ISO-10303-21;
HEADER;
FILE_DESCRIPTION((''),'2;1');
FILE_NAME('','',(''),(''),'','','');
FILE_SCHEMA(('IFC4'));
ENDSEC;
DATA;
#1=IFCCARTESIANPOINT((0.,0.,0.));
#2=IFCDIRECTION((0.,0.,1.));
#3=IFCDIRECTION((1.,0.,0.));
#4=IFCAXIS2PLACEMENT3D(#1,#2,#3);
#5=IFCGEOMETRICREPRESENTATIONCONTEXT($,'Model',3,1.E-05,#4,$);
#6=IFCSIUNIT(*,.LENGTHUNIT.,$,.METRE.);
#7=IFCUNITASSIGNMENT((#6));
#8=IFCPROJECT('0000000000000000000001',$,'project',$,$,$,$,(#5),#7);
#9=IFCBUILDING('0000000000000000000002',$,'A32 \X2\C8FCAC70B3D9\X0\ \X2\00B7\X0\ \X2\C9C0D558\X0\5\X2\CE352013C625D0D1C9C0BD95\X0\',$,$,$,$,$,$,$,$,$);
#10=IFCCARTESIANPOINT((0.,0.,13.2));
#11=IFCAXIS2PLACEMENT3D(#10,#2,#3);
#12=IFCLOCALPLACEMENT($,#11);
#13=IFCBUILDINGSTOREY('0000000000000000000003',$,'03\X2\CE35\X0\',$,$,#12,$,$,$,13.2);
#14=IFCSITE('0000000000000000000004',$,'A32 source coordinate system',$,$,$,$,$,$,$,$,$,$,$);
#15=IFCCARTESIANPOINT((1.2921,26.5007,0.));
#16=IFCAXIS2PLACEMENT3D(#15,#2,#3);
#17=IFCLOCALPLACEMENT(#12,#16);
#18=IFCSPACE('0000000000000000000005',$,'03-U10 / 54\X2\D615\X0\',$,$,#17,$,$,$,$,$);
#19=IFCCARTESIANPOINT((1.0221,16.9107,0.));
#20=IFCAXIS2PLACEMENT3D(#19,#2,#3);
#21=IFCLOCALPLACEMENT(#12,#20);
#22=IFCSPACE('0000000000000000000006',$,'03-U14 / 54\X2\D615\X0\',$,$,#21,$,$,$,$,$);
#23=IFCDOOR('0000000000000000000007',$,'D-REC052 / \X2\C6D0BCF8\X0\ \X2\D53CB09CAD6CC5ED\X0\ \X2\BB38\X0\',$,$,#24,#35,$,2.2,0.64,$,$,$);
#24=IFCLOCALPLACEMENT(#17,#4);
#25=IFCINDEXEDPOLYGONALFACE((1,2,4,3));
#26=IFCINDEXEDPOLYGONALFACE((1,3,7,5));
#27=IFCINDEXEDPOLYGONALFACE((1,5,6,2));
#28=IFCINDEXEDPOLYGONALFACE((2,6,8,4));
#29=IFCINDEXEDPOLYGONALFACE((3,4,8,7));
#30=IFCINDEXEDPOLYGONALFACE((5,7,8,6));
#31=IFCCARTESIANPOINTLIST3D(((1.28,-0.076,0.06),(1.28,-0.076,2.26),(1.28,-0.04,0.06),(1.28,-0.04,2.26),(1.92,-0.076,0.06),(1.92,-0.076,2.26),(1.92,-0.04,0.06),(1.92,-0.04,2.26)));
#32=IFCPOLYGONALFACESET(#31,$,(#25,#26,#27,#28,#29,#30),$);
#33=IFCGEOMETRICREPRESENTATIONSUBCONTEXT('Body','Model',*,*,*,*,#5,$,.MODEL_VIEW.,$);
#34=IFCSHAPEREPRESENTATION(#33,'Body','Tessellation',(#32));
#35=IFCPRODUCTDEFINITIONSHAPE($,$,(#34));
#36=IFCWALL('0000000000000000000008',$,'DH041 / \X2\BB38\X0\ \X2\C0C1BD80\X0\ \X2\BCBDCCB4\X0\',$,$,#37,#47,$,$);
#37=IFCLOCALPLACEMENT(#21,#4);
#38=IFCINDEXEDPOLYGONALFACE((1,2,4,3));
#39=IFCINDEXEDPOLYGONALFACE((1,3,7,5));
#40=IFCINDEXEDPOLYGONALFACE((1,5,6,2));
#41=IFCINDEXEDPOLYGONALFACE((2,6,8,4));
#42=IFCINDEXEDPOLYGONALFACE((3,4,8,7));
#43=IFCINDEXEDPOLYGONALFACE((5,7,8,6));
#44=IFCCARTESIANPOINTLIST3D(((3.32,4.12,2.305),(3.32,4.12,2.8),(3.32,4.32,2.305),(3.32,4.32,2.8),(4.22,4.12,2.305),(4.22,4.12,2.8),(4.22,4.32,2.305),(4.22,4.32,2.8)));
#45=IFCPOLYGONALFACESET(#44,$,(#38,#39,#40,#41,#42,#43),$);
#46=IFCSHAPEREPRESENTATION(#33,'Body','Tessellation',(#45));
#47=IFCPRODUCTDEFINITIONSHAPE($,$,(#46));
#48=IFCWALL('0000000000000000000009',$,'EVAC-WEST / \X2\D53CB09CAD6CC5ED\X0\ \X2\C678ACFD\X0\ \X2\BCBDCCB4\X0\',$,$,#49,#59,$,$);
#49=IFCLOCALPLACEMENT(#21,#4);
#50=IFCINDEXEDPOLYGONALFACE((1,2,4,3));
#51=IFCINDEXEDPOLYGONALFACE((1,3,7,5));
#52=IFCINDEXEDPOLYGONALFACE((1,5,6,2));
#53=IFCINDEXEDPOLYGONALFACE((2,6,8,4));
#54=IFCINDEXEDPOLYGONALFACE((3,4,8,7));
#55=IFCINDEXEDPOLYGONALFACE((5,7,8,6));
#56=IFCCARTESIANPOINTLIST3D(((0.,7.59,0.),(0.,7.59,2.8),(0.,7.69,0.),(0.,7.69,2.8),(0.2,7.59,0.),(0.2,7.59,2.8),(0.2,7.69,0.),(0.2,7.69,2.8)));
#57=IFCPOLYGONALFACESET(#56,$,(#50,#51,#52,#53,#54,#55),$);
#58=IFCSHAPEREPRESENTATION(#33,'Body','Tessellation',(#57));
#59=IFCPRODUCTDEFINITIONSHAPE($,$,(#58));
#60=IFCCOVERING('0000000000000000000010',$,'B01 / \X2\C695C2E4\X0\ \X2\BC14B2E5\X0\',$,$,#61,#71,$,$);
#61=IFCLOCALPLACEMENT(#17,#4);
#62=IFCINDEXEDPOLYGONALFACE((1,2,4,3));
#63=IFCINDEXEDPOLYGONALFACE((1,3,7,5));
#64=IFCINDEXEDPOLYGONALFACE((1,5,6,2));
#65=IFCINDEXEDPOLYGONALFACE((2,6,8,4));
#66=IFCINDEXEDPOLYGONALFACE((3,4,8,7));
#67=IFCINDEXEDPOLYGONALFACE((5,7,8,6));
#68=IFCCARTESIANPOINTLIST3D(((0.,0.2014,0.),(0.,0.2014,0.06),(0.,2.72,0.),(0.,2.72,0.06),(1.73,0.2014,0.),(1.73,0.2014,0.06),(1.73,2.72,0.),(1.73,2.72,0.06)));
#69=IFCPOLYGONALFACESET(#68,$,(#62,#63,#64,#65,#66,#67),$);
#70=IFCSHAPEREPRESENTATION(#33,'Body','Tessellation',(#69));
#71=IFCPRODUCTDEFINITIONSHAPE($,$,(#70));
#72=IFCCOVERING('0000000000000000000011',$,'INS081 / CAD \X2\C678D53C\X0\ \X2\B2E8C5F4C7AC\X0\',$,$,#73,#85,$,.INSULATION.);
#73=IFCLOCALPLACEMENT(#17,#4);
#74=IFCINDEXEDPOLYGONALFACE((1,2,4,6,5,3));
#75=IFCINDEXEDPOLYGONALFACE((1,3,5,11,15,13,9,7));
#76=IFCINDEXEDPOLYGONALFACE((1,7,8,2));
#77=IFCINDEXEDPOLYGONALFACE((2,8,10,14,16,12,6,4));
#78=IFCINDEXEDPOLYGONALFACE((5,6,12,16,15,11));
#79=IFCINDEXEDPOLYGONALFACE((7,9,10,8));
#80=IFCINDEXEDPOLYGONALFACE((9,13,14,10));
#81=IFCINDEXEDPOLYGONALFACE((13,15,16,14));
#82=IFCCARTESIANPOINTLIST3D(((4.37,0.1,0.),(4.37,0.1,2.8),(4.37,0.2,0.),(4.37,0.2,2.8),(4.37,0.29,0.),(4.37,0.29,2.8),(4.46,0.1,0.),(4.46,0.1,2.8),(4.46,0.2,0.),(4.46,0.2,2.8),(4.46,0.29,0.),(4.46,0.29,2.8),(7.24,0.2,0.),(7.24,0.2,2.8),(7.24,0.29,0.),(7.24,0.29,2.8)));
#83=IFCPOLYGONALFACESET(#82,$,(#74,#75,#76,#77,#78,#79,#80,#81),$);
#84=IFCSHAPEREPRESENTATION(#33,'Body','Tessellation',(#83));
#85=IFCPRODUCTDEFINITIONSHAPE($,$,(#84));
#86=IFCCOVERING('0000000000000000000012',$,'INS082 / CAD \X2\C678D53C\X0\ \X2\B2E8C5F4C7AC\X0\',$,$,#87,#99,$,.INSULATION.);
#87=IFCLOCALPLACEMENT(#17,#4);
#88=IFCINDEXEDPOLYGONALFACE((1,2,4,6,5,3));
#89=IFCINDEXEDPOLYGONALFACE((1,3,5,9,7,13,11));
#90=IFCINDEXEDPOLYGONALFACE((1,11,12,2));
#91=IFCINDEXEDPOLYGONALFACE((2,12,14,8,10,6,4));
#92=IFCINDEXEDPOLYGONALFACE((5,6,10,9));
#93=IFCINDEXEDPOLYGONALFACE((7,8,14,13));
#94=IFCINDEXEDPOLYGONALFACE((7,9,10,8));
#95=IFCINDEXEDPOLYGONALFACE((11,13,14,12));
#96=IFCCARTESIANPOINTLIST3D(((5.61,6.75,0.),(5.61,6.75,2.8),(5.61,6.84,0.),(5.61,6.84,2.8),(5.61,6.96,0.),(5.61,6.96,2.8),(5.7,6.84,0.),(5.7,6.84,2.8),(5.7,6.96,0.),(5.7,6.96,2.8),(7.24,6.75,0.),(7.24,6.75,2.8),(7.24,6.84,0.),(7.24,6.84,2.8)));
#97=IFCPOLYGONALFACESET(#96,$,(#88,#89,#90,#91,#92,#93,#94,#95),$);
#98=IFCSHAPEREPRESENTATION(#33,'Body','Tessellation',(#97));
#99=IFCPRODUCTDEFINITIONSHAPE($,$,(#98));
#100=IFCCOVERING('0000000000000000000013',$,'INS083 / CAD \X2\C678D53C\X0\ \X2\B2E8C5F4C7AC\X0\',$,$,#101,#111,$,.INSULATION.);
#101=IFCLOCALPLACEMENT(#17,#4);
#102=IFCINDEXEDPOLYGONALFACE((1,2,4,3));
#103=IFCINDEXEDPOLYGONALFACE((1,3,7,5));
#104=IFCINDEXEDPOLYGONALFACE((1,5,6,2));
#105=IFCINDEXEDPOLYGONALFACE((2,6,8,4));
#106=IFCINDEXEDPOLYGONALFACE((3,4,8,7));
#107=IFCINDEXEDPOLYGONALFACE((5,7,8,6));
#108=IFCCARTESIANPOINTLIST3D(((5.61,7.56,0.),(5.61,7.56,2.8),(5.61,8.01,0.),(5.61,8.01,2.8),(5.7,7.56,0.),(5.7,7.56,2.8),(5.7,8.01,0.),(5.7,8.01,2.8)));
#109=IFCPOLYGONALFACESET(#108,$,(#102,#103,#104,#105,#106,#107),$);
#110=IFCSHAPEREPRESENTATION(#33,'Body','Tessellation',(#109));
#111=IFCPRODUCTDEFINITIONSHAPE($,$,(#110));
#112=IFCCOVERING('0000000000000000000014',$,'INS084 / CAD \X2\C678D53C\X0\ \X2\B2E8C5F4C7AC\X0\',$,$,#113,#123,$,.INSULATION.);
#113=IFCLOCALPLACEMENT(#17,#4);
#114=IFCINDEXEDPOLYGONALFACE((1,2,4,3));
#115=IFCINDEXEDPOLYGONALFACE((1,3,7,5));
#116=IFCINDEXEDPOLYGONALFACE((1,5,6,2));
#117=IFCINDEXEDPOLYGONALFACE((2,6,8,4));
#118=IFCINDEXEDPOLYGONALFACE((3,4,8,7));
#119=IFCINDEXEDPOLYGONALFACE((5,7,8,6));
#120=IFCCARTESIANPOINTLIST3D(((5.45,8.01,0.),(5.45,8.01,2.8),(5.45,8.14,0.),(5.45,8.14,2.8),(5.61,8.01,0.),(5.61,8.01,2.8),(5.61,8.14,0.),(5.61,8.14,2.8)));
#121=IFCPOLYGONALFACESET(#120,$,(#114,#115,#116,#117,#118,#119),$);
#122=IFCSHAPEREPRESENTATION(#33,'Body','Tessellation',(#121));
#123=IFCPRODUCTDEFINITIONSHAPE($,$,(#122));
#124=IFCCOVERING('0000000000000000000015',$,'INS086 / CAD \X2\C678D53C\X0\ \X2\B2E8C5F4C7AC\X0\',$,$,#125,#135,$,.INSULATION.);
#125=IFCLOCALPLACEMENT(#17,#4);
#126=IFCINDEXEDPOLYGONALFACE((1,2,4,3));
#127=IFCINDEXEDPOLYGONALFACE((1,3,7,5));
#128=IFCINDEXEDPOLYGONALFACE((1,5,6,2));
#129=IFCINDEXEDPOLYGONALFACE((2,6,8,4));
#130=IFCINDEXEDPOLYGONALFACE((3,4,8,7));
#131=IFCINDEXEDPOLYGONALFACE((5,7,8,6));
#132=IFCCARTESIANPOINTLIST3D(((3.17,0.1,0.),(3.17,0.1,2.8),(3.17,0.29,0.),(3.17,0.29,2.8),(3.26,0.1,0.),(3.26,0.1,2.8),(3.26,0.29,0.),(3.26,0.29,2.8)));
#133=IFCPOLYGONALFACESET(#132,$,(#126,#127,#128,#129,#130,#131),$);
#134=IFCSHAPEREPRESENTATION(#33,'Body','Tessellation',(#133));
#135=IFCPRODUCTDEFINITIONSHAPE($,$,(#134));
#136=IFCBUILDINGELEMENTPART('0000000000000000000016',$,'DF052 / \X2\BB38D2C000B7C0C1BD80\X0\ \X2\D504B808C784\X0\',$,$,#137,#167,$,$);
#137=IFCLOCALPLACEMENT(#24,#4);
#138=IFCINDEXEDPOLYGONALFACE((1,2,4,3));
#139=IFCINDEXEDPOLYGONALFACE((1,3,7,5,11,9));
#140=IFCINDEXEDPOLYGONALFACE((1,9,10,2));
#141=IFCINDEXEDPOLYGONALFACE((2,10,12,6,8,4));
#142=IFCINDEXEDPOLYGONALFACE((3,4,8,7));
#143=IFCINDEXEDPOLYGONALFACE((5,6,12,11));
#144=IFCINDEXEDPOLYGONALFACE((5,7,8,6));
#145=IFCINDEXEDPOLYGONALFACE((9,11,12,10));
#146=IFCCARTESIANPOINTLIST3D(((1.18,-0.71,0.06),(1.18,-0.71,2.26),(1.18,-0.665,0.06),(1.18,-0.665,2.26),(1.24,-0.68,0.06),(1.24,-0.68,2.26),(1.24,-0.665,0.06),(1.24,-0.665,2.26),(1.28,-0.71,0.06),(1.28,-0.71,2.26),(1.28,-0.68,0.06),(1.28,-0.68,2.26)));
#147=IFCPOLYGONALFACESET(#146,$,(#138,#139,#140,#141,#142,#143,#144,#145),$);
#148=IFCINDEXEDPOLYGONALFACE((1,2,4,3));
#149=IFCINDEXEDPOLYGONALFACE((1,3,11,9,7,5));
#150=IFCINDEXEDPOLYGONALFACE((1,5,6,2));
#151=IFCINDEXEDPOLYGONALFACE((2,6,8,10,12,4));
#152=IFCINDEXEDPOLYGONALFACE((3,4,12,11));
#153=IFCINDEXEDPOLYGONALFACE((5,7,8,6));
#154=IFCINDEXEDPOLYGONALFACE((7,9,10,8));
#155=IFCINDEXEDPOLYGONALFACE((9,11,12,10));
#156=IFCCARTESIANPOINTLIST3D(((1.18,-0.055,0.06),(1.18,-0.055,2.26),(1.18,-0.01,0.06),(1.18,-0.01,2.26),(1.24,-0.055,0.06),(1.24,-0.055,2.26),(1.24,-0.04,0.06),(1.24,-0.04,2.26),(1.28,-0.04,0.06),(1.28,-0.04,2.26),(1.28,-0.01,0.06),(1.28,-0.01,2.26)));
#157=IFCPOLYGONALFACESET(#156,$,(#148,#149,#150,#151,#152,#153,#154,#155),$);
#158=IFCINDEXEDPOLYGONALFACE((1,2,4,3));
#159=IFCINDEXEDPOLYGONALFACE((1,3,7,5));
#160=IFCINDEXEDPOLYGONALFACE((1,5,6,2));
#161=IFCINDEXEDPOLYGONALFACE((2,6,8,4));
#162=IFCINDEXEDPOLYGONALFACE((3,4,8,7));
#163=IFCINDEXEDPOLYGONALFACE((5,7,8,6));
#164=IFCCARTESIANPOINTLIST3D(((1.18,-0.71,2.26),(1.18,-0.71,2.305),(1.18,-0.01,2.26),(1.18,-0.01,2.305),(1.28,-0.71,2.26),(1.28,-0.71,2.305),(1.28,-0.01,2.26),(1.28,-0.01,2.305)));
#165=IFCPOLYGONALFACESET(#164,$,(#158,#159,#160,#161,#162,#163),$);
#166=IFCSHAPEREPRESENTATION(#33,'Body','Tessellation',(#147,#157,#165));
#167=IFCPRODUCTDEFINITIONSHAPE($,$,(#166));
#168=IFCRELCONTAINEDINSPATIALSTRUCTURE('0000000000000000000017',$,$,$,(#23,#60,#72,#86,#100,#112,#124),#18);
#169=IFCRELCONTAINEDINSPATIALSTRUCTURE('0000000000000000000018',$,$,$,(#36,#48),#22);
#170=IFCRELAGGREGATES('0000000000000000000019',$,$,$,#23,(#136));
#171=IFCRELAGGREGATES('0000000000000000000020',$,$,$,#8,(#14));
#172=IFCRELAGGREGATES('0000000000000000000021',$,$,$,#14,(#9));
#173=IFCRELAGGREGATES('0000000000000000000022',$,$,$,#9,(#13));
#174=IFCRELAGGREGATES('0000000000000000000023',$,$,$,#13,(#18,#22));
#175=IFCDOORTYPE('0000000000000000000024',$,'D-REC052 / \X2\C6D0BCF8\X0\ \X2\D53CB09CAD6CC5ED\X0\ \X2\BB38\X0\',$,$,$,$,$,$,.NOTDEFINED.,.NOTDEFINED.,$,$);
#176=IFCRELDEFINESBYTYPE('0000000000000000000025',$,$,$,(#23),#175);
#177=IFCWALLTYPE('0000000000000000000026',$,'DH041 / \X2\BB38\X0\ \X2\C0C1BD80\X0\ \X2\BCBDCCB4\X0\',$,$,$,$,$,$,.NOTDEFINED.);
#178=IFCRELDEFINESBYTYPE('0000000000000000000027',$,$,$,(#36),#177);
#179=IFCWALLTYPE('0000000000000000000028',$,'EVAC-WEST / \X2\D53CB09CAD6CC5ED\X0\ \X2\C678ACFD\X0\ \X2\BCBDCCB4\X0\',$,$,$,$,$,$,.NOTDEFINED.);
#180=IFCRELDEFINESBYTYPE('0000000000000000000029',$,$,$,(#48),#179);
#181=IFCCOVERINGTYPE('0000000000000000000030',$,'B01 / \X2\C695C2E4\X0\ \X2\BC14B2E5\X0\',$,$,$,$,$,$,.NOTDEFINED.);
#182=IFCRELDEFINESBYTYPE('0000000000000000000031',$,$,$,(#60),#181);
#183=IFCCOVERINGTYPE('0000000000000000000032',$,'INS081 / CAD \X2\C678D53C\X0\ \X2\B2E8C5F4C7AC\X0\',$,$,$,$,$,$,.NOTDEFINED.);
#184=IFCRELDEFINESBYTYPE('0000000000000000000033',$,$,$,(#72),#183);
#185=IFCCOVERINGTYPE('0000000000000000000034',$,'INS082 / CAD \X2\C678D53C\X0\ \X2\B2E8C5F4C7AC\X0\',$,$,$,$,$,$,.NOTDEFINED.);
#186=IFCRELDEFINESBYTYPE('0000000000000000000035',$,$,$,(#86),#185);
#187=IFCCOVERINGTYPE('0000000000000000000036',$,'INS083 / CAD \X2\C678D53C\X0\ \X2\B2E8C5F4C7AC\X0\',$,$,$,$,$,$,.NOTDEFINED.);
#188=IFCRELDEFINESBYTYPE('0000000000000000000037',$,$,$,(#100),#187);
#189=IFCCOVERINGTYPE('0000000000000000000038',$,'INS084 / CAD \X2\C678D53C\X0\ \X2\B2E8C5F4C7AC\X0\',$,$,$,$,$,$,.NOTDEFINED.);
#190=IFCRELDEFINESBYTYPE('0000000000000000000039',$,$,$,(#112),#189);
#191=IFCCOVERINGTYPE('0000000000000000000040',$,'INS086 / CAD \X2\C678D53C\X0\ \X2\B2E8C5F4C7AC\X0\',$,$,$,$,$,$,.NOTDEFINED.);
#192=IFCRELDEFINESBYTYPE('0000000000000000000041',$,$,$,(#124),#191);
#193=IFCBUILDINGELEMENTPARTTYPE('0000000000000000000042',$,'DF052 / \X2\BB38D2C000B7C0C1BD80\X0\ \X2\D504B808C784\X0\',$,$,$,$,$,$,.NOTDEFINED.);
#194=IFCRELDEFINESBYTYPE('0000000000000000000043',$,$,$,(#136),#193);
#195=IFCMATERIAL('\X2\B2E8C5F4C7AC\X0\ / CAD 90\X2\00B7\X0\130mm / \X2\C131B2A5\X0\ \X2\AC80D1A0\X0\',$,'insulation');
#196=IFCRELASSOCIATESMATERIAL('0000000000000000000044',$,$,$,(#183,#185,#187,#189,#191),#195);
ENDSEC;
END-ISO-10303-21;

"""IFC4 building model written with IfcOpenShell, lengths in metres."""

from ifc_helpers import new_model, si_unit, frame, origin, origin_with_axes, place, context, subcontext, project, spatial, polyline, outline, extrude, source, transform, mapped, material, type_object, type_shapes, element, aggregate, save


model = new_model("IFC4")

# Units and contexts
model_context = context("Model", 3, precision=1e-05, world=origin_with_axes())
body_context = subcontext(model_context, "Body", "Model", "MODEL_VIEW")
ifc_project = project(units=[si_unit("LENGTHUNIT", "METRE")], contexts=[model_context])

# Site, building, storey, space
storey_placement = place(None, frame((0.0, 0.0, 13.2), z_axis=(0.0, 0.0, 1.0), x_axis=(1.0, 0.0, 0.0)))
space_1_placement = place(storey_placement, frame((1.2921, 26.5007, 0.0), z_axis=(0.0, 0.0, 1.0), x_axis=(1.0, 0.0, 0.0)))
site = spatial("IfcSite", under=ifc_project, Name="A32 source coordinate system")
building = spatial("IfcBuilding", under=site, Name="A32 주거동 · 지하5층–옥탑지붕")
storey = spatial("IfcBuildingStorey", under=building, at=storey_placement, Name="03층", Elevation=13.2)
space_1 = spatial("IfcSpace", under=storey, at=space_1_placement, Name="03-U10 / 54형")

# Door
door_type_1 = type_object("IfcDoorType", Name="D-REC052 / 원본 피난구역 문", OperationType="NOTDEFINED", PredefinedType="NOTDEFINED")
shared_shape_1 = source(origin(), body_context, "Body", "SweptSolid", [
    extrude(outline(polyline([(1.92, -0.076), (1.28, -0.076), (1.28, -0.04), (1.92, -0.04), (1.92, -0.076)])), frame((0.0, 0.0, 0.06)), (0.0, 0.0, 1.0), 2.2),
])
type_shapes(door_type_1, [shared_shape_1])
door_1_placement = place(space_1_placement, origin_with_axes())
door_1 = element("IfcDoor", 1, at=door_1_placement, inside=space_1, type_object=door_type_1, Name="D-REC052 / 원본 피난구역 문", OverallHeight=2.2, OverallWidth=0.64, context=body_context, shape_type="MappedRepresentation", body=[
    mapped(shared_shape_1, transform((0.0, 0.0, 0.0), scale=1.0)),
])

# Shared definitions
space_2_placement = place(storey_placement, frame((1.0221, 16.9107, 0.0), z_axis=(0.0, 0.0, 1.0), x_axis=(1.0, 0.0, 0.0)))
space_2 = spatial("IfcSpace", under=storey, at=space_2_placement, Name="03-U14 / 54형")

# Walls
wall_type_1 = type_object("IfcWallType", Name="DH041 / 문 상부 벽체", PredefinedType="NOTDEFINED")
shared_shape_2 = source(origin(), body_context, "Body", "SweptSolid", [
    extrude(outline(polyline([(4.22, 4.12), (3.32, 4.12), (3.32, 4.32), (4.22, 4.32), (4.22, 4.12)])), frame((0.0, 0.0, 2.305)), (0.0, 0.0, 1.0), 0.495),
])
type_shapes(wall_type_1, [shared_shape_2])
wall_1_placement = place(space_2_placement, origin_with_axes())
element("IfcWall", 2, at=wall_1_placement, inside=space_2, type_object=wall_type_1, Name="DH041 / 문 상부 벽체", context=body_context, shape_type="MappedRepresentation", body=[
    mapped(shared_shape_2, transform((0.0, 0.0, 0.0), scale=1.0)),
])
wall_type_2 = type_object("IfcWallType", Name="EVAC-WEST / 피난구역 외곽 벽체", PredefinedType="NOTDEFINED")
shared_shape_3 = source(origin(), body_context, "Body", "SweptSolid", [
    extrude(outline(polyline([(0.2, 7.59), (0.0, 7.59), (0.0, 7.69), (0.2, 7.69), (0.2, 7.59)])), origin(), (0.0, 0.0, 1.0), 2.8),
])
type_shapes(wall_type_2, [shared_shape_3])
wall_2_placement = place(space_2_placement, origin_with_axes())
element("IfcWall", 3, at=wall_2_placement, inside=space_2, type_object=wall_type_2, Name="EVAC-WEST / 피난구역 외곽 벽체", context=body_context, shape_type="MappedRepresentation", body=[
    mapped(shared_shape_3, transform((0.0, 0.0, 0.0), scale=1.0)),
])

# Coverings
covering_type_1 = type_object("IfcCoveringType", Name="B01 / 욕실 바닥", PredefinedType="NOTDEFINED")
shared_shape_4 = source(origin(), body_context, "Body", "SweptSolid", [
    extrude(outline(polyline([(0.0, 0.2014), (0.0, 2.72), (1.73, 2.72), (1.73, 0.2014), (0.0, 0.2014)])), origin(), (0.0, 0.0, 1.0), 0.06),
])
type_shapes(covering_type_1, [shared_shape_4])
covering_1_placement = place(space_1_placement, origin_with_axes())
element("IfcCovering", 4, at=covering_1_placement, inside=space_1, type_object=covering_type_1, Name="B01 / 욕실 바닥", context=body_context, shape_type="MappedRepresentation", body=[
    mapped(shared_shape_4, transform((0.0, 0.0, 0.0), scale=1.0)),
])
ifc_material = material(Name="단열재 / CAD 90·130mm / 성능 검토", Category="insulation")
covering_type_2 = type_object("IfcCoveringType", Name="INS081 / CAD 외피 단열재", PredefinedType="NOTDEFINED", material=ifc_material)
shared_shape_5 = source(origin(), body_context, "Body", "SweptSolid", [
    extrude(outline(polyline([(4.37, 0.2), (4.37, 0.29), (4.46, 0.29), (7.24, 0.29), (7.24, 0.2), (4.46, 0.2), (4.46, 0.1), (4.37, 0.1), (4.37, 0.2)])), origin(), (0.0, 0.0, 1.0), 2.8),
])
type_shapes(covering_type_2, [shared_shape_5])
covering_2_placement = place(space_1_placement, origin_with_axes())
element("IfcCovering", 5, at=covering_2_placement, inside=space_1, type_object=covering_type_2, Name="INS081 / CAD 외피 단열재", PredefinedType="INSULATION", context=body_context, shape_type="MappedRepresentation", body=[
    mapped(shared_shape_5, transform((0.0, 0.0, 0.0), scale=1.0)),
])
covering_type_3 = type_object("IfcCoveringType", Name="INS082 / CAD 외피 단열재", PredefinedType="NOTDEFINED", material=ifc_material)
shared_shape_6 = source(origin(), body_context, "Body", "SweptSolid", [
    extrude(outline(polyline([(5.61, 6.84), (5.61, 6.96), (5.7, 6.96), (5.7, 6.84), (7.24, 6.84), (7.24, 6.75), (5.61, 6.75), (5.61, 6.84)])), origin(), (0.0, 0.0, 1.0), 2.8),
])
type_shapes(covering_type_3, [shared_shape_6])
covering_3_placement = place(space_1_placement, origin_with_axes())
element("IfcCovering", 6, at=covering_3_placement, inside=space_1, type_object=covering_type_3, Name="INS082 / CAD 외피 단열재", PredefinedType="INSULATION", context=body_context, shape_type="MappedRepresentation", body=[
    mapped(shared_shape_6, transform((0.0, 0.0, 0.0), scale=1.0)),
])
covering_type_4 = type_object("IfcCoveringType", Name="INS083 / CAD 외피 단열재", PredefinedType="NOTDEFINED", material=ifc_material)
shared_shape_7 = source(origin(), body_context, "Body", "SweptSolid", [
    extrude(outline(polyline([(5.61, 8.01), (5.7, 8.01), (5.7, 7.56), (5.61, 7.56), (5.61, 8.01)])), origin(), (0.0, 0.0, 1.0), 2.8),
])
type_shapes(covering_type_4, [shared_shape_7])
covering_4_placement = place(space_1_placement, origin_with_axes())
element("IfcCovering", 7, at=covering_4_placement, inside=space_1, type_object=covering_type_4, Name="INS083 / CAD 외피 단열재", PredefinedType="INSULATION", context=body_context, shape_type="MappedRepresentation", body=[
    mapped(shared_shape_7, transform((0.0, 0.0, 0.0), scale=1.0)),
])
covering_type_5 = type_object("IfcCoveringType", Name="INS084 / CAD 외피 단열재", PredefinedType="NOTDEFINED", material=ifc_material)
shared_shape_8 = source(origin(), body_context, "Body", "SweptSolid", [
    extrude(outline(polyline([(5.45, 8.01), (5.45, 8.14), (5.61, 8.14), (5.61, 8.01), (5.45, 8.01)])), origin(), (0.0, 0.0, 1.0), 2.8),
])
type_shapes(covering_type_5, [shared_shape_8])
covering_5_placement = place(space_1_placement, origin_with_axes())
element("IfcCovering", 8, at=covering_5_placement, inside=space_1, type_object=covering_type_5, Name="INS084 / CAD 외피 단열재", PredefinedType="INSULATION", context=body_context, shape_type="MappedRepresentation", body=[
    mapped(shared_shape_8, transform((0.0, 0.0, 0.0), scale=1.0)),
])
covering_type_6 = type_object("IfcCoveringType", Name="INS086 / CAD 외피 단열재", PredefinedType="NOTDEFINED", material=ifc_material)
shared_shape_9 = source(origin(), body_context, "Body", "SweptSolid", [
    extrude(outline(polyline([(3.17, 0.1), (3.17, 0.29), (3.26, 0.29), (3.26, 0.1), (3.17, 0.1)])), origin(), (0.0, 0.0, 1.0), 2.8),
])
type_shapes(covering_type_6, [shared_shape_9])
covering_6_placement = place(space_1_placement, origin_with_axes())
element("IfcCovering", 9, at=covering_6_placement, inside=space_1, type_object=covering_type_6, Name="INS086 / CAD 외피 단열재", PredefinedType="INSULATION", context=body_context, shape_type="MappedRepresentation", body=[
    mapped(shared_shape_9, transform((0.0, 0.0, 0.0), scale=1.0)),
])

# Building element part
building_element_part_type_1 = type_object("IfcBuildingElementPartType", Name="DF052 / 문틀·상부 프레임", PredefinedType="NOTDEFINED")
shared_shape_10 = source(origin(), body_context, "Body", "SweptSolid", [
    extrude(outline(polyline([(1.18, -0.71), (1.18, -0.665), (1.24, -0.665), (1.24, -0.68), (1.28, -0.68), (1.28, -0.71), (1.18, -0.71)])), frame((0.0, 0.0, 0.06)), (0.0, 0.0, 1.0), 2.2),
    extrude(outline(polyline([(1.28, -0.04), (1.24, -0.04), (1.24, -0.055), (1.18, -0.055), (1.18, -0.01), (1.28, -0.01), (1.28, -0.04)])), frame((0.0, 0.0, 0.06)), (0.0, 0.0, 1.0), 2.2),
    extrude(outline(polyline([(1.18, -0.71), (1.18, -0.01), (1.28, -0.01), (1.28, -0.71), (1.18, -0.71)])), frame((0.0, 0.0, 2.26)), (0.0, 0.0, 1.0), 0.045),
])
type_shapes(building_element_part_type_1, [shared_shape_10])
building_element_part_1_placement = place(door_1_placement, origin_with_axes())
building_element_part_1 = element("IfcBuildingElementPart", 10, at=building_element_part_1_placement, type_object=building_element_part_type_1, Name="DF052 / 문틀·상부 프레임", context=body_context, shape_type="MappedRepresentation", body=[
    mapped(shared_shape_10, transform((0.0, 0.0, 0.0), scale=1.0)),
])
aggregate(door_1, [building_element_part_1])

save(model, "model.ifc")
